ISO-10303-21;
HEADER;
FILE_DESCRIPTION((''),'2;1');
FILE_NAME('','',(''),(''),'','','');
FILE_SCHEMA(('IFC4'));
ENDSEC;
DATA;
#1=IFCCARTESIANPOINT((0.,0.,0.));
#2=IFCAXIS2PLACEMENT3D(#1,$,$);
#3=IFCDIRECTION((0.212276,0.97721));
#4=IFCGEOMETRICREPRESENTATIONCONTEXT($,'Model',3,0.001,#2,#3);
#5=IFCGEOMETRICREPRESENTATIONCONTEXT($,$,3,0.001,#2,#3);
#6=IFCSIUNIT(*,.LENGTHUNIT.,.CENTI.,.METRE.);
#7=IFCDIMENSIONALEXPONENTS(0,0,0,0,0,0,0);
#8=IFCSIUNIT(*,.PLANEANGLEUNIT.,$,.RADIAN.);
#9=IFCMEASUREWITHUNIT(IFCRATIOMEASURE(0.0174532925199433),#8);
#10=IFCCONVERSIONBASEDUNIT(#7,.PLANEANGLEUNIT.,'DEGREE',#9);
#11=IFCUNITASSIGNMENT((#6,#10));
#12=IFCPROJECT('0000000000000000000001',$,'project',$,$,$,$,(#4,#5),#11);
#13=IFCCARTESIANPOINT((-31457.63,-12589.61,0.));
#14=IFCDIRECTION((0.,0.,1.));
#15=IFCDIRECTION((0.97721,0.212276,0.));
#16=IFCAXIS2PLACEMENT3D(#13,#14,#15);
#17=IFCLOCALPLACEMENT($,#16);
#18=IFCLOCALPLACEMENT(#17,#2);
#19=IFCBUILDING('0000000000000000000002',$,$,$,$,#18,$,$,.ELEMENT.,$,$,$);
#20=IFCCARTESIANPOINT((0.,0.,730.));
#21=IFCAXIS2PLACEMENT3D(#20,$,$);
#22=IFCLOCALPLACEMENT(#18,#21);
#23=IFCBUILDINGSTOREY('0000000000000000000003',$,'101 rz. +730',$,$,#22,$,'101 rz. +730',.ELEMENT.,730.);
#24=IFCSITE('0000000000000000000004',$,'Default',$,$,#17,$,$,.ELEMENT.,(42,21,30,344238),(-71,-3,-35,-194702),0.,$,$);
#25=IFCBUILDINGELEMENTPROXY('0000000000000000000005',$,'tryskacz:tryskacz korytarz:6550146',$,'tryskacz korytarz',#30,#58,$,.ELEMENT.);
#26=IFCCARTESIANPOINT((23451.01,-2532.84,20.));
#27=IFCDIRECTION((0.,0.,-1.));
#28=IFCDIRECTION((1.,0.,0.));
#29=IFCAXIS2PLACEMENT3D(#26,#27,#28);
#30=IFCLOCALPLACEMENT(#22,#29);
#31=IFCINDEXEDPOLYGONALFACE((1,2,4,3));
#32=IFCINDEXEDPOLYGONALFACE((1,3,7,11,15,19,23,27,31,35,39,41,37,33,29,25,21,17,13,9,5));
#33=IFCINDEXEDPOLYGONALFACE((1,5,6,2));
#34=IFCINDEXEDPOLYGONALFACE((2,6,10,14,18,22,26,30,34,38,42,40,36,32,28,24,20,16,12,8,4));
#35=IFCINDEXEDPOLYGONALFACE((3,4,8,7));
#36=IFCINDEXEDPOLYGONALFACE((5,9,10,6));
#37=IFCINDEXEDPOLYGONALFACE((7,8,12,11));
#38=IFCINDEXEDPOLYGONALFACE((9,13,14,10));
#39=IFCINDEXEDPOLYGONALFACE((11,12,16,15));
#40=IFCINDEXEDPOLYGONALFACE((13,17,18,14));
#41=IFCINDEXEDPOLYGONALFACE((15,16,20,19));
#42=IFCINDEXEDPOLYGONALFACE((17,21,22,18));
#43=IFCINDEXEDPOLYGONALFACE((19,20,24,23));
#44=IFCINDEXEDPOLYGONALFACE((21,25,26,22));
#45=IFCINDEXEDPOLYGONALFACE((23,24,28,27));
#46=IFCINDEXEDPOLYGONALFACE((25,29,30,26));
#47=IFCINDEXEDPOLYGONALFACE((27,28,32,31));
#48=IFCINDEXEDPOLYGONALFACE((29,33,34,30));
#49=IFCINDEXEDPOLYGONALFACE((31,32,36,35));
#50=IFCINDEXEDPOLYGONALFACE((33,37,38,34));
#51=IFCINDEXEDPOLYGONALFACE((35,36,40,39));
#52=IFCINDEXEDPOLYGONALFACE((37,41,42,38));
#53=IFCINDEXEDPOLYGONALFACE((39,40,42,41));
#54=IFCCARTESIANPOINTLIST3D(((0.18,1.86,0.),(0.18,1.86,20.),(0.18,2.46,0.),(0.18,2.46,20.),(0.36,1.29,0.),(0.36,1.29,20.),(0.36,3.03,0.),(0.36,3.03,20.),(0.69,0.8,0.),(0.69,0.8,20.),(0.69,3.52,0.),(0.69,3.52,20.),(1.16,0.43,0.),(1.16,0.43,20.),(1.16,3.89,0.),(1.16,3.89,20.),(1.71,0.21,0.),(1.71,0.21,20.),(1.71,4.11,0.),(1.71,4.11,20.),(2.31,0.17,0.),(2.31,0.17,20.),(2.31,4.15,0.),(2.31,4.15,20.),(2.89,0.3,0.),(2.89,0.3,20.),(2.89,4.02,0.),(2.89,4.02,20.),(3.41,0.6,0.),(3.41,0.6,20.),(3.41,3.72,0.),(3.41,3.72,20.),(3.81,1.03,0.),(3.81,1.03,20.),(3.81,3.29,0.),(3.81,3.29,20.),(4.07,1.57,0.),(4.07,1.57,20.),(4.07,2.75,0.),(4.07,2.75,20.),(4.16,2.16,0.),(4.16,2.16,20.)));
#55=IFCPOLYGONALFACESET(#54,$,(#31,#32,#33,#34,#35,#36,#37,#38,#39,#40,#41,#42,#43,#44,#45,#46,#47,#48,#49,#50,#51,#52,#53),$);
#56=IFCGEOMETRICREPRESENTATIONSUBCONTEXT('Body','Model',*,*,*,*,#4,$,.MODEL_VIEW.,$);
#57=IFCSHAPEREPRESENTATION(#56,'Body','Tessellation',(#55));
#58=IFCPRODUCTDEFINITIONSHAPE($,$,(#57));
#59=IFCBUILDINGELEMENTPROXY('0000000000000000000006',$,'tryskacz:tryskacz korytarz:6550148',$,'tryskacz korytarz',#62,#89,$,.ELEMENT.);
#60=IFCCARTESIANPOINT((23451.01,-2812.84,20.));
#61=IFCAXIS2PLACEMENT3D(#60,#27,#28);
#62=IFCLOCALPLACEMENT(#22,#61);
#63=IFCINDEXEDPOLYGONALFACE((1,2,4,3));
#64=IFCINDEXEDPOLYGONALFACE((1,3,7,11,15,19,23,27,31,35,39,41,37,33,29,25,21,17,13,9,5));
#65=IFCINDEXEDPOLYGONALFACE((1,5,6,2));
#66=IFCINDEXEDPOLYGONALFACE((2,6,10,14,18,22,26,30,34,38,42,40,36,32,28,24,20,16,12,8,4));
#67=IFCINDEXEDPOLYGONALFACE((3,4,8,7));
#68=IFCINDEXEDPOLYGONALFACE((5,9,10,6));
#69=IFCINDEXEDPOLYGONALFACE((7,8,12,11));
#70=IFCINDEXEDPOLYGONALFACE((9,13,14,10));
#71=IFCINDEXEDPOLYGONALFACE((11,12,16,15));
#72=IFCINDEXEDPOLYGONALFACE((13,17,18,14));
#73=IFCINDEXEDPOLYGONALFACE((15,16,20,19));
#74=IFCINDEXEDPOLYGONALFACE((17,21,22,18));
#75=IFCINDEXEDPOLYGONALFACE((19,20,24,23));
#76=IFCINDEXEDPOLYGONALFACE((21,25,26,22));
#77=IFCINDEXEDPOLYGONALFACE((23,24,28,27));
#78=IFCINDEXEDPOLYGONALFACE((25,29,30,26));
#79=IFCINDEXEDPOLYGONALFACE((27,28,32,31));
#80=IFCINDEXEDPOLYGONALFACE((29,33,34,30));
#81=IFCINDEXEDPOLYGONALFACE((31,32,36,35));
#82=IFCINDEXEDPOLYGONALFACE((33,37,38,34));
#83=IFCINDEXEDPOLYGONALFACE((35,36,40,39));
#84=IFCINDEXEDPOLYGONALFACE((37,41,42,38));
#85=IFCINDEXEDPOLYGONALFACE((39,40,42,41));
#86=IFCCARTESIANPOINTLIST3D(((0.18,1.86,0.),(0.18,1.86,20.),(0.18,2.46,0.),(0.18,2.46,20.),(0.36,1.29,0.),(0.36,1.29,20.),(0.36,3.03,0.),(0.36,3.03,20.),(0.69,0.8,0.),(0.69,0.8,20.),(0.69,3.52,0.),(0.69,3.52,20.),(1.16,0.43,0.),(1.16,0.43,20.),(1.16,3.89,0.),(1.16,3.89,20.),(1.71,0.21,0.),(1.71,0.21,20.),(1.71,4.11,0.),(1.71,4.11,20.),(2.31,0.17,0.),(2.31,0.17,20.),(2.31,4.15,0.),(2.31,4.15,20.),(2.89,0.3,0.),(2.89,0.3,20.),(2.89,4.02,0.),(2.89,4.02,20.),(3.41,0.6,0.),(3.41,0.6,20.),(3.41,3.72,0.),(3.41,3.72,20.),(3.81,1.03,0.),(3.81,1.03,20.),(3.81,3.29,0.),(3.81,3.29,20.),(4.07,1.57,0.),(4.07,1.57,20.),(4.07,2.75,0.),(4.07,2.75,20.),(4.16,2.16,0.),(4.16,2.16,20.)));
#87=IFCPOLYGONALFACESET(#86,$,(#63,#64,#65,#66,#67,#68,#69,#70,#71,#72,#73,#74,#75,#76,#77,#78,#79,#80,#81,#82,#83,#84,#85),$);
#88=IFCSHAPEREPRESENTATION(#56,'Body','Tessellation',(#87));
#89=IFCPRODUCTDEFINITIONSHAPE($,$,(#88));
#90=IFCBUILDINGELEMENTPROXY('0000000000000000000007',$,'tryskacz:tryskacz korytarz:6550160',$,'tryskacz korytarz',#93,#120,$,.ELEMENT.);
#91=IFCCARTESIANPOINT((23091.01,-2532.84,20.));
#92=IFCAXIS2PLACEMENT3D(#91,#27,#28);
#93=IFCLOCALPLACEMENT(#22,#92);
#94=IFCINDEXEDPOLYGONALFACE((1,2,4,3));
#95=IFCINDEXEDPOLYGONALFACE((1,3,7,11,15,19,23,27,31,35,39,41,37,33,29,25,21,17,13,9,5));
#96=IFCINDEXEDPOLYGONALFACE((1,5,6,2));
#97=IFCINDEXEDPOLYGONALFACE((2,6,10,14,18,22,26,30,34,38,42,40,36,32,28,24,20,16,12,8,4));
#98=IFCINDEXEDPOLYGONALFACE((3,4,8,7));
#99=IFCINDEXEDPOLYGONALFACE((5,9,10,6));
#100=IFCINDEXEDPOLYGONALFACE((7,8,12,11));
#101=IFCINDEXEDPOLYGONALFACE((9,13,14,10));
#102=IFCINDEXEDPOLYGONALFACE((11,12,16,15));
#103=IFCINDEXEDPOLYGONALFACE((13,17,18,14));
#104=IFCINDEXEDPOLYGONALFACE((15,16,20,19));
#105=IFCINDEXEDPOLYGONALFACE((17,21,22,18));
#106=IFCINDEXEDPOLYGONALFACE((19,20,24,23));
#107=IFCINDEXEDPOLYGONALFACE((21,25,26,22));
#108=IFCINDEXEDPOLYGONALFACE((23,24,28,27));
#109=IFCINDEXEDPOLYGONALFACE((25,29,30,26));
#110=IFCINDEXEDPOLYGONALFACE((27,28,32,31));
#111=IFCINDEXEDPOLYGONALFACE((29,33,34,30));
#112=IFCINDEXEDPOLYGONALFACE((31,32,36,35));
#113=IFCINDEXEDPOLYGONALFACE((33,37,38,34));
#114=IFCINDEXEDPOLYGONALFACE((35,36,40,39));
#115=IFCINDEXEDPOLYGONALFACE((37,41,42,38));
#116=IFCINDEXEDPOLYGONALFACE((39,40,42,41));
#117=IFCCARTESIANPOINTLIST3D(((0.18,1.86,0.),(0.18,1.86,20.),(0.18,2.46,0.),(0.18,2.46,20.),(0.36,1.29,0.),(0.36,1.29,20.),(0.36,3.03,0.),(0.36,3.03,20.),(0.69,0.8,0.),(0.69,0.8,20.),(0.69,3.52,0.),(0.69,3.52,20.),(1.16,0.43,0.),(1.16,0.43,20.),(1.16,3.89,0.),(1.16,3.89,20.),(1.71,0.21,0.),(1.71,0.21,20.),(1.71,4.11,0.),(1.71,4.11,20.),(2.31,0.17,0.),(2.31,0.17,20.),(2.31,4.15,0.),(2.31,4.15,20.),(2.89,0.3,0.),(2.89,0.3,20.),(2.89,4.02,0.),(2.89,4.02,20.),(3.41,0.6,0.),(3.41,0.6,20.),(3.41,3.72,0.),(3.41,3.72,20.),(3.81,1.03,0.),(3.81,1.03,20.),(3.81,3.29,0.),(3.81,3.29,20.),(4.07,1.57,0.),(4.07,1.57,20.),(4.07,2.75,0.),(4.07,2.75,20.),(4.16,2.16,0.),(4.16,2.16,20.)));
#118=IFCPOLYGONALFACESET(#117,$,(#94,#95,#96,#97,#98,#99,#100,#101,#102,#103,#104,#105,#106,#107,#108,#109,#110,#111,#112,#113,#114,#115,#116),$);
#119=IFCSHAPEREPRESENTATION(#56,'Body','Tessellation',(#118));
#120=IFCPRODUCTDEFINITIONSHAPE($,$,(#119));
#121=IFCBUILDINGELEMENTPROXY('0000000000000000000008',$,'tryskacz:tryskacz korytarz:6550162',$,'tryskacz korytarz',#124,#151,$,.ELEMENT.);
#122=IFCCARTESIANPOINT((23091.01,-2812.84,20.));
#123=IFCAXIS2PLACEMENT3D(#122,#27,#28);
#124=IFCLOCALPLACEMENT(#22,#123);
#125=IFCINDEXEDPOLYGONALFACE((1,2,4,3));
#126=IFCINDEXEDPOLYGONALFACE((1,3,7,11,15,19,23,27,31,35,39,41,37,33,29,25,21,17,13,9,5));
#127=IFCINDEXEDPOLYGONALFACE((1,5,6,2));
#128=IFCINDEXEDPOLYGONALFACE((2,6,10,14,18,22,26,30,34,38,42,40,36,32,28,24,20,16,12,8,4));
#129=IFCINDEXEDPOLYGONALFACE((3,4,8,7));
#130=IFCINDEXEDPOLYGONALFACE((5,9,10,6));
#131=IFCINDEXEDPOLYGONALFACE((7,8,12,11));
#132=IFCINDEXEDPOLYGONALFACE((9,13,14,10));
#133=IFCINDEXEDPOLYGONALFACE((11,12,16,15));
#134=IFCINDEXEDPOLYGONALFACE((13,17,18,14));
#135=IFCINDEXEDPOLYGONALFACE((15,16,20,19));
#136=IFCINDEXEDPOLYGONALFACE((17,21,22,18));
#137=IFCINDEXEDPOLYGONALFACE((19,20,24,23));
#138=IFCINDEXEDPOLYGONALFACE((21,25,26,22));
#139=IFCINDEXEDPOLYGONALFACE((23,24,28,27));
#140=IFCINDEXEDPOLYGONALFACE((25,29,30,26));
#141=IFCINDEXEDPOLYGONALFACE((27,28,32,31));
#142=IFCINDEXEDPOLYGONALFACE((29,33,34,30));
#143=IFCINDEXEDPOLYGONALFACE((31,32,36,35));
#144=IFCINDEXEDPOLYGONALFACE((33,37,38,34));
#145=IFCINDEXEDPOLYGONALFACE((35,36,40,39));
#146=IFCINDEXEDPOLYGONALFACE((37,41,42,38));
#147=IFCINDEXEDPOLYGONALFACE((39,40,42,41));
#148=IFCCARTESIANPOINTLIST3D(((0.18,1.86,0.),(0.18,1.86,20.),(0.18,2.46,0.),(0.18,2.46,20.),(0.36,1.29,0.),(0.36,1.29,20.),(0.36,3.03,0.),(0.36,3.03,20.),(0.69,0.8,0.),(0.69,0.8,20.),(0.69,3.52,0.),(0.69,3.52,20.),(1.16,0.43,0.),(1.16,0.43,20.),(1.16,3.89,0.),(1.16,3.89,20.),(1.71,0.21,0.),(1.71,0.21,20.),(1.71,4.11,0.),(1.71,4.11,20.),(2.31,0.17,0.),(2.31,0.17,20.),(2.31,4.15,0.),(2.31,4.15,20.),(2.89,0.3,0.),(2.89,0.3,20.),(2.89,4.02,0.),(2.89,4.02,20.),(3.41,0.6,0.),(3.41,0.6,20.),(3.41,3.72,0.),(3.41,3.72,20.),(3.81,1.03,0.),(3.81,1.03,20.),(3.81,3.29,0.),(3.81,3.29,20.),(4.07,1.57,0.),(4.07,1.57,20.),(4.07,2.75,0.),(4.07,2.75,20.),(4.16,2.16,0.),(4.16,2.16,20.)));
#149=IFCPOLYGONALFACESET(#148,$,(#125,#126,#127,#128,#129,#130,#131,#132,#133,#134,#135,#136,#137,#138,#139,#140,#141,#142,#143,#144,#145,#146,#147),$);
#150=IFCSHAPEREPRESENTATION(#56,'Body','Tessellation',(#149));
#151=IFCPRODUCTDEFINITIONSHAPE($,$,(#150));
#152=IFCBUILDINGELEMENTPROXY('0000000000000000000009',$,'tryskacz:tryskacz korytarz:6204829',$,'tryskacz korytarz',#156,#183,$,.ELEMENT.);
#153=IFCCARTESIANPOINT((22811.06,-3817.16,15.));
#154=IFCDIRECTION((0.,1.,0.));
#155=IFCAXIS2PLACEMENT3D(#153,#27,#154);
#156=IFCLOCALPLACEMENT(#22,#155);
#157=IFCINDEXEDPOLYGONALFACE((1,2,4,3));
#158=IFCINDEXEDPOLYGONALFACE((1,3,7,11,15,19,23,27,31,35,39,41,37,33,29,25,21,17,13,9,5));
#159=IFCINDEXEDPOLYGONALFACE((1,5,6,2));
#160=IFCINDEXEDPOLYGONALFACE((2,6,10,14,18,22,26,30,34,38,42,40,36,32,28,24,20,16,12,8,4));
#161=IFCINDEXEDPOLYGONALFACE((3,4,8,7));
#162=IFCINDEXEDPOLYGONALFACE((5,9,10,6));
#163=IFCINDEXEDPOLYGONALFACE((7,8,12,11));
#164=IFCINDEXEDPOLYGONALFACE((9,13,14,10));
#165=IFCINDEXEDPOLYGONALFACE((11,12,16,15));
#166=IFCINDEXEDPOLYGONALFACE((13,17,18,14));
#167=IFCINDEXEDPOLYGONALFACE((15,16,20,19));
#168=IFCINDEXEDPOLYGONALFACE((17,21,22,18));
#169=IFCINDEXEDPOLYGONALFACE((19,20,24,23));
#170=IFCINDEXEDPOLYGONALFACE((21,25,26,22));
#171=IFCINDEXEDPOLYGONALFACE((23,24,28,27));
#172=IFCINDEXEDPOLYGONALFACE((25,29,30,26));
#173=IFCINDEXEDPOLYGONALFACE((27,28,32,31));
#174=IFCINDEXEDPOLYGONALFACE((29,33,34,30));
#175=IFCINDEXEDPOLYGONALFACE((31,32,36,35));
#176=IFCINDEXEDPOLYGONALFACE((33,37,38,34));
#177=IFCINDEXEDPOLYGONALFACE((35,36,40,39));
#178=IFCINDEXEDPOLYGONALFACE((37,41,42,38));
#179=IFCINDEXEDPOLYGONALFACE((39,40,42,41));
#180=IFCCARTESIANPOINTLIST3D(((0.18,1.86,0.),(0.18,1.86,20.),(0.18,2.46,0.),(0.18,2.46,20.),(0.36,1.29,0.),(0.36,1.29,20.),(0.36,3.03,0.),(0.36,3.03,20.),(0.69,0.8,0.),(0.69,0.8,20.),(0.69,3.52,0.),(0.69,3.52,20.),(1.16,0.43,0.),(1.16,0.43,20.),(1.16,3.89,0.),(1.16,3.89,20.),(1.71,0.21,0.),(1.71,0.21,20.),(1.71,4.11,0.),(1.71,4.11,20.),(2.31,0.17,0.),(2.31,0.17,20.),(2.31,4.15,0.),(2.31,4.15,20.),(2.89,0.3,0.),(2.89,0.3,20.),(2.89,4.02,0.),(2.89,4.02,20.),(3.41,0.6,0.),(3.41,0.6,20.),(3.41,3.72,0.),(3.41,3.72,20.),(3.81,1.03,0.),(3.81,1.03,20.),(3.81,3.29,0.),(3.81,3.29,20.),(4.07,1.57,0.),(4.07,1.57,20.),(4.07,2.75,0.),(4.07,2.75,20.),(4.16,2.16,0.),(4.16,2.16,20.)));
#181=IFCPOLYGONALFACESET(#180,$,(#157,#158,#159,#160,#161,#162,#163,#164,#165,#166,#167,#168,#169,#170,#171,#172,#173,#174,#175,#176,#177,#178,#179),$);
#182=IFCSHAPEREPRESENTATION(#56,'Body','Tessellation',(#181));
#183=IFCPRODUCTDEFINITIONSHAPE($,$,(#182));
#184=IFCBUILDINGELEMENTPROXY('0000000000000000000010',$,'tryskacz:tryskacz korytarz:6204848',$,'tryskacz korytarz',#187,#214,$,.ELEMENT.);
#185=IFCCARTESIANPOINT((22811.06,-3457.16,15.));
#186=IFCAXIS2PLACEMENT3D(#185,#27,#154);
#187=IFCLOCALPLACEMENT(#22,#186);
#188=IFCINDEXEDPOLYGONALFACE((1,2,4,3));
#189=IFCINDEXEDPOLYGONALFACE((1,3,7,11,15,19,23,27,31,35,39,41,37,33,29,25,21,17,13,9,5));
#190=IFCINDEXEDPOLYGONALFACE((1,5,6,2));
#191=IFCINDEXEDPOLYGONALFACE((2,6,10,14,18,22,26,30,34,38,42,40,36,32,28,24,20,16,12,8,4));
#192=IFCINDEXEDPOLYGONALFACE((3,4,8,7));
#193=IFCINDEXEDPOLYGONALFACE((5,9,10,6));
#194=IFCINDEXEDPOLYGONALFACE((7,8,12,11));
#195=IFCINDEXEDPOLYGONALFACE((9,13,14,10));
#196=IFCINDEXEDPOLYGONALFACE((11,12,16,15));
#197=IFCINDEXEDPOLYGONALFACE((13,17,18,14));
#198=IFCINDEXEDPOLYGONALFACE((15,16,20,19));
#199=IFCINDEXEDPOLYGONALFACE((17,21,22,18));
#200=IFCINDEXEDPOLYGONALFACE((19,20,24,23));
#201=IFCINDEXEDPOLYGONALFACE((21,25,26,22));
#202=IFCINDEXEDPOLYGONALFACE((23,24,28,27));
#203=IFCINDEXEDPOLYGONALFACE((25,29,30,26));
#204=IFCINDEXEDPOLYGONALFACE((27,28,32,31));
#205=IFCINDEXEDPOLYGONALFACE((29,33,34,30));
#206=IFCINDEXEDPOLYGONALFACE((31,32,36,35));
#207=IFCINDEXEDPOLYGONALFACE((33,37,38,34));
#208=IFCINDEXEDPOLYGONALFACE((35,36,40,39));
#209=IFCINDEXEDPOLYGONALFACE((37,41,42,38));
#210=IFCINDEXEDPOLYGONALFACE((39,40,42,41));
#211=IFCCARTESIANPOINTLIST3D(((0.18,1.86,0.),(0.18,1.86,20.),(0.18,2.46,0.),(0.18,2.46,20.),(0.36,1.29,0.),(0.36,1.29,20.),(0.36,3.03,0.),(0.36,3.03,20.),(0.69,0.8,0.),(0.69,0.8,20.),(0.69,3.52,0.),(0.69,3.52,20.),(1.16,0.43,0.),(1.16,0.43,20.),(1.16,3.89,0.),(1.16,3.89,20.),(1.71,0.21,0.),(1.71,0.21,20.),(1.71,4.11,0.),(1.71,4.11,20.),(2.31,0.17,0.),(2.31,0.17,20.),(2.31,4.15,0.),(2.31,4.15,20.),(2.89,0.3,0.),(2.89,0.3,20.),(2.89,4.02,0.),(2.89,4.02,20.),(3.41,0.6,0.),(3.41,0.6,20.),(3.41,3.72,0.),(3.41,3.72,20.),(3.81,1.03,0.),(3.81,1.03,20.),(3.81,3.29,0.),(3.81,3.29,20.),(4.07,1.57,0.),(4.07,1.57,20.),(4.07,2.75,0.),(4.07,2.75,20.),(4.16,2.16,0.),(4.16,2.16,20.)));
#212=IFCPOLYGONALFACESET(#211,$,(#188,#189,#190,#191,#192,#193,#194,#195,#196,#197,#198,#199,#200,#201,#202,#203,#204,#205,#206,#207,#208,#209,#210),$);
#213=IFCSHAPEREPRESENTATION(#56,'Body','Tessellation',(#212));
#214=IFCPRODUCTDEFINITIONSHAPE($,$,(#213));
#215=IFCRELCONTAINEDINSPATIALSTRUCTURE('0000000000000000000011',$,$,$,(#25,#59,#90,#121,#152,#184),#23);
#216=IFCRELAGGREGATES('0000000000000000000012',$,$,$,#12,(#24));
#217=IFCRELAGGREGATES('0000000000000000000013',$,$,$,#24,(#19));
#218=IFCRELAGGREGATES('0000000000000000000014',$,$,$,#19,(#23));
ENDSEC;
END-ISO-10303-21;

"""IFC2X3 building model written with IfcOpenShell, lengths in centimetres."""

from ifc_helpers import new_model, entity, si_unit, converted_unit, direction, frame, frame_2d, origin, place, context, subcontext, project, spatial, circle, extrude, source, transform, mapped, element, save


model = new_model("IFC2X3")

# Units and contexts
model_context = context("Model", 3, precision=0.001, world=origin(), true_north=direction((0.212276, 0.97721)))
context_of_model = context(None, 3, precision=0.001, world=origin(), true_north=direction((0.212276, 0.97721)))
body_context = subcontext(model_context, "Body", "Model", "MODEL_VIEW")
ifc_project = project(units=[si_unit("LENGTHUNIT", "METRE", prefix="CENTI"), converted_unit("PLANEANGLEUNIT", "DEGREE", entity("IfcRatioMeasure", 0.0174532925199433), si_unit("PLANEANGLEUNIT", "RADIAN"), dimensions=[0, 0, 0, 0, 0, 0, 0])], contexts=[model_context, context_of_model])

# Site, building, storey
site_placement = place(None, frame((-31457.63, -12589.61, 0.0), z_axis=(0.0, 0.0, 1.0), x_axis=(0.97721, 0.212276, 0.0)))
site = spatial("IfcSite", under=ifc_project, at=site_placement, Name="Default", CompositionType="ELEMENT", RefLatitude=(42, 21, 30, 344238), RefLongitude=(-71, -3, -35, -194702), RefElevation=0.0)
building_placement = place(site_placement, origin())
building = spatial("IfcBuilding", under=site, at=building_placement, CompositionType="ELEMENT")
storey_placement = place(building_placement, frame((0.0, 0.0, 730.0)))
storey = spatial("IfcBuildingStorey", under=building, at=storey_placement, Name="101 rz. +730", LongName="101 rz. +730", CompositionType="ELEMENT", Elevation=730.0)

# Building element proxies
shared_shape_1 = source(origin(), body_context, "Body", "SweptSolid", [
    extrude(circle(Radius=2.0, at=frame_2d((0.0, 0.0), x_axis=(1.0, 0.0))), frame((2.16, 2.16, 0.0)), (0.0, 0.0, 1.0), 20.0),
])
for number, where, z_axis, x_axis, name in (
    (1, (23451.01, -2532.84, 20.0), (0.0, 0.0, -1.0), (1.0, 0.0, 0.0), "tryskacz:tryskacz korytarz:6550146"),
    (2, (23451.01, -2812.84, 20.0), (0.0, 0.0, -1.0), (1.0, 0.0, 0.0), "tryskacz:tryskacz korytarz:6550148"),
    (3, (23091.01, -2532.84, 20.0), (0.0, 0.0, -1.0), (1.0, 0.0, 0.0), "tryskacz:tryskacz korytarz:6550160"),
    (4, (23091.01, -2812.84, 20.0), (0.0, 0.0, -1.0), (1.0, 0.0, 0.0), "tryskacz:tryskacz korytarz:6550162"),
):
    element("IfcBuildingElementProxy", number, at=place(storey_placement, frame(where, z_axis=z_axis, x_axis=x_axis)), inside=storey, Name=name, ObjectType="tryskacz korytarz", CompositionType="ELEMENT", context=body_context, shape_type="MappedRepresentation", body=[
        mapped(shared_shape_1, transform((0.0, 0.0, 0.0), scale=1.0)),
    ])
shared_shape_2 = source(origin(), body_context, "Body", "SweptSolid", [
    extrude(circle(Radius=2.0, at=frame_2d((0.0, 0.0), x_axis=(1.0, 0.0))), frame((2.16, 2.16, 0.0)), (0.0, 0.0, 1.0), 20.0),
])
for number, where, z_axis, x_axis, name in (
    (5, (22811.06, -3817.16, 15.0), (0.0, 0.0, -1.0), (0.0, 1.0, 0.0), "tryskacz:tryskacz korytarz:6204829"),
    (6, (22811.06, -3457.16, 15.0), (0.0, 0.0, -1.0), (0.0, 1.0, 0.0), "tryskacz:tryskacz korytarz:6204848"),
):
    element("IfcBuildingElementProxy", number, at=place(storey_placement, frame(where, z_axis=z_axis, x_axis=x_axis)), inside=storey, Name=name, ObjectType="tryskacz korytarz", CompositionType="ELEMENT", context=body_context, shape_type="MappedRepresentation", body=[
        mapped(shared_shape_2, transform((0.0, 0.0, 0.0), scale=1.0)),
    ])

save(model, "model.ifc")
